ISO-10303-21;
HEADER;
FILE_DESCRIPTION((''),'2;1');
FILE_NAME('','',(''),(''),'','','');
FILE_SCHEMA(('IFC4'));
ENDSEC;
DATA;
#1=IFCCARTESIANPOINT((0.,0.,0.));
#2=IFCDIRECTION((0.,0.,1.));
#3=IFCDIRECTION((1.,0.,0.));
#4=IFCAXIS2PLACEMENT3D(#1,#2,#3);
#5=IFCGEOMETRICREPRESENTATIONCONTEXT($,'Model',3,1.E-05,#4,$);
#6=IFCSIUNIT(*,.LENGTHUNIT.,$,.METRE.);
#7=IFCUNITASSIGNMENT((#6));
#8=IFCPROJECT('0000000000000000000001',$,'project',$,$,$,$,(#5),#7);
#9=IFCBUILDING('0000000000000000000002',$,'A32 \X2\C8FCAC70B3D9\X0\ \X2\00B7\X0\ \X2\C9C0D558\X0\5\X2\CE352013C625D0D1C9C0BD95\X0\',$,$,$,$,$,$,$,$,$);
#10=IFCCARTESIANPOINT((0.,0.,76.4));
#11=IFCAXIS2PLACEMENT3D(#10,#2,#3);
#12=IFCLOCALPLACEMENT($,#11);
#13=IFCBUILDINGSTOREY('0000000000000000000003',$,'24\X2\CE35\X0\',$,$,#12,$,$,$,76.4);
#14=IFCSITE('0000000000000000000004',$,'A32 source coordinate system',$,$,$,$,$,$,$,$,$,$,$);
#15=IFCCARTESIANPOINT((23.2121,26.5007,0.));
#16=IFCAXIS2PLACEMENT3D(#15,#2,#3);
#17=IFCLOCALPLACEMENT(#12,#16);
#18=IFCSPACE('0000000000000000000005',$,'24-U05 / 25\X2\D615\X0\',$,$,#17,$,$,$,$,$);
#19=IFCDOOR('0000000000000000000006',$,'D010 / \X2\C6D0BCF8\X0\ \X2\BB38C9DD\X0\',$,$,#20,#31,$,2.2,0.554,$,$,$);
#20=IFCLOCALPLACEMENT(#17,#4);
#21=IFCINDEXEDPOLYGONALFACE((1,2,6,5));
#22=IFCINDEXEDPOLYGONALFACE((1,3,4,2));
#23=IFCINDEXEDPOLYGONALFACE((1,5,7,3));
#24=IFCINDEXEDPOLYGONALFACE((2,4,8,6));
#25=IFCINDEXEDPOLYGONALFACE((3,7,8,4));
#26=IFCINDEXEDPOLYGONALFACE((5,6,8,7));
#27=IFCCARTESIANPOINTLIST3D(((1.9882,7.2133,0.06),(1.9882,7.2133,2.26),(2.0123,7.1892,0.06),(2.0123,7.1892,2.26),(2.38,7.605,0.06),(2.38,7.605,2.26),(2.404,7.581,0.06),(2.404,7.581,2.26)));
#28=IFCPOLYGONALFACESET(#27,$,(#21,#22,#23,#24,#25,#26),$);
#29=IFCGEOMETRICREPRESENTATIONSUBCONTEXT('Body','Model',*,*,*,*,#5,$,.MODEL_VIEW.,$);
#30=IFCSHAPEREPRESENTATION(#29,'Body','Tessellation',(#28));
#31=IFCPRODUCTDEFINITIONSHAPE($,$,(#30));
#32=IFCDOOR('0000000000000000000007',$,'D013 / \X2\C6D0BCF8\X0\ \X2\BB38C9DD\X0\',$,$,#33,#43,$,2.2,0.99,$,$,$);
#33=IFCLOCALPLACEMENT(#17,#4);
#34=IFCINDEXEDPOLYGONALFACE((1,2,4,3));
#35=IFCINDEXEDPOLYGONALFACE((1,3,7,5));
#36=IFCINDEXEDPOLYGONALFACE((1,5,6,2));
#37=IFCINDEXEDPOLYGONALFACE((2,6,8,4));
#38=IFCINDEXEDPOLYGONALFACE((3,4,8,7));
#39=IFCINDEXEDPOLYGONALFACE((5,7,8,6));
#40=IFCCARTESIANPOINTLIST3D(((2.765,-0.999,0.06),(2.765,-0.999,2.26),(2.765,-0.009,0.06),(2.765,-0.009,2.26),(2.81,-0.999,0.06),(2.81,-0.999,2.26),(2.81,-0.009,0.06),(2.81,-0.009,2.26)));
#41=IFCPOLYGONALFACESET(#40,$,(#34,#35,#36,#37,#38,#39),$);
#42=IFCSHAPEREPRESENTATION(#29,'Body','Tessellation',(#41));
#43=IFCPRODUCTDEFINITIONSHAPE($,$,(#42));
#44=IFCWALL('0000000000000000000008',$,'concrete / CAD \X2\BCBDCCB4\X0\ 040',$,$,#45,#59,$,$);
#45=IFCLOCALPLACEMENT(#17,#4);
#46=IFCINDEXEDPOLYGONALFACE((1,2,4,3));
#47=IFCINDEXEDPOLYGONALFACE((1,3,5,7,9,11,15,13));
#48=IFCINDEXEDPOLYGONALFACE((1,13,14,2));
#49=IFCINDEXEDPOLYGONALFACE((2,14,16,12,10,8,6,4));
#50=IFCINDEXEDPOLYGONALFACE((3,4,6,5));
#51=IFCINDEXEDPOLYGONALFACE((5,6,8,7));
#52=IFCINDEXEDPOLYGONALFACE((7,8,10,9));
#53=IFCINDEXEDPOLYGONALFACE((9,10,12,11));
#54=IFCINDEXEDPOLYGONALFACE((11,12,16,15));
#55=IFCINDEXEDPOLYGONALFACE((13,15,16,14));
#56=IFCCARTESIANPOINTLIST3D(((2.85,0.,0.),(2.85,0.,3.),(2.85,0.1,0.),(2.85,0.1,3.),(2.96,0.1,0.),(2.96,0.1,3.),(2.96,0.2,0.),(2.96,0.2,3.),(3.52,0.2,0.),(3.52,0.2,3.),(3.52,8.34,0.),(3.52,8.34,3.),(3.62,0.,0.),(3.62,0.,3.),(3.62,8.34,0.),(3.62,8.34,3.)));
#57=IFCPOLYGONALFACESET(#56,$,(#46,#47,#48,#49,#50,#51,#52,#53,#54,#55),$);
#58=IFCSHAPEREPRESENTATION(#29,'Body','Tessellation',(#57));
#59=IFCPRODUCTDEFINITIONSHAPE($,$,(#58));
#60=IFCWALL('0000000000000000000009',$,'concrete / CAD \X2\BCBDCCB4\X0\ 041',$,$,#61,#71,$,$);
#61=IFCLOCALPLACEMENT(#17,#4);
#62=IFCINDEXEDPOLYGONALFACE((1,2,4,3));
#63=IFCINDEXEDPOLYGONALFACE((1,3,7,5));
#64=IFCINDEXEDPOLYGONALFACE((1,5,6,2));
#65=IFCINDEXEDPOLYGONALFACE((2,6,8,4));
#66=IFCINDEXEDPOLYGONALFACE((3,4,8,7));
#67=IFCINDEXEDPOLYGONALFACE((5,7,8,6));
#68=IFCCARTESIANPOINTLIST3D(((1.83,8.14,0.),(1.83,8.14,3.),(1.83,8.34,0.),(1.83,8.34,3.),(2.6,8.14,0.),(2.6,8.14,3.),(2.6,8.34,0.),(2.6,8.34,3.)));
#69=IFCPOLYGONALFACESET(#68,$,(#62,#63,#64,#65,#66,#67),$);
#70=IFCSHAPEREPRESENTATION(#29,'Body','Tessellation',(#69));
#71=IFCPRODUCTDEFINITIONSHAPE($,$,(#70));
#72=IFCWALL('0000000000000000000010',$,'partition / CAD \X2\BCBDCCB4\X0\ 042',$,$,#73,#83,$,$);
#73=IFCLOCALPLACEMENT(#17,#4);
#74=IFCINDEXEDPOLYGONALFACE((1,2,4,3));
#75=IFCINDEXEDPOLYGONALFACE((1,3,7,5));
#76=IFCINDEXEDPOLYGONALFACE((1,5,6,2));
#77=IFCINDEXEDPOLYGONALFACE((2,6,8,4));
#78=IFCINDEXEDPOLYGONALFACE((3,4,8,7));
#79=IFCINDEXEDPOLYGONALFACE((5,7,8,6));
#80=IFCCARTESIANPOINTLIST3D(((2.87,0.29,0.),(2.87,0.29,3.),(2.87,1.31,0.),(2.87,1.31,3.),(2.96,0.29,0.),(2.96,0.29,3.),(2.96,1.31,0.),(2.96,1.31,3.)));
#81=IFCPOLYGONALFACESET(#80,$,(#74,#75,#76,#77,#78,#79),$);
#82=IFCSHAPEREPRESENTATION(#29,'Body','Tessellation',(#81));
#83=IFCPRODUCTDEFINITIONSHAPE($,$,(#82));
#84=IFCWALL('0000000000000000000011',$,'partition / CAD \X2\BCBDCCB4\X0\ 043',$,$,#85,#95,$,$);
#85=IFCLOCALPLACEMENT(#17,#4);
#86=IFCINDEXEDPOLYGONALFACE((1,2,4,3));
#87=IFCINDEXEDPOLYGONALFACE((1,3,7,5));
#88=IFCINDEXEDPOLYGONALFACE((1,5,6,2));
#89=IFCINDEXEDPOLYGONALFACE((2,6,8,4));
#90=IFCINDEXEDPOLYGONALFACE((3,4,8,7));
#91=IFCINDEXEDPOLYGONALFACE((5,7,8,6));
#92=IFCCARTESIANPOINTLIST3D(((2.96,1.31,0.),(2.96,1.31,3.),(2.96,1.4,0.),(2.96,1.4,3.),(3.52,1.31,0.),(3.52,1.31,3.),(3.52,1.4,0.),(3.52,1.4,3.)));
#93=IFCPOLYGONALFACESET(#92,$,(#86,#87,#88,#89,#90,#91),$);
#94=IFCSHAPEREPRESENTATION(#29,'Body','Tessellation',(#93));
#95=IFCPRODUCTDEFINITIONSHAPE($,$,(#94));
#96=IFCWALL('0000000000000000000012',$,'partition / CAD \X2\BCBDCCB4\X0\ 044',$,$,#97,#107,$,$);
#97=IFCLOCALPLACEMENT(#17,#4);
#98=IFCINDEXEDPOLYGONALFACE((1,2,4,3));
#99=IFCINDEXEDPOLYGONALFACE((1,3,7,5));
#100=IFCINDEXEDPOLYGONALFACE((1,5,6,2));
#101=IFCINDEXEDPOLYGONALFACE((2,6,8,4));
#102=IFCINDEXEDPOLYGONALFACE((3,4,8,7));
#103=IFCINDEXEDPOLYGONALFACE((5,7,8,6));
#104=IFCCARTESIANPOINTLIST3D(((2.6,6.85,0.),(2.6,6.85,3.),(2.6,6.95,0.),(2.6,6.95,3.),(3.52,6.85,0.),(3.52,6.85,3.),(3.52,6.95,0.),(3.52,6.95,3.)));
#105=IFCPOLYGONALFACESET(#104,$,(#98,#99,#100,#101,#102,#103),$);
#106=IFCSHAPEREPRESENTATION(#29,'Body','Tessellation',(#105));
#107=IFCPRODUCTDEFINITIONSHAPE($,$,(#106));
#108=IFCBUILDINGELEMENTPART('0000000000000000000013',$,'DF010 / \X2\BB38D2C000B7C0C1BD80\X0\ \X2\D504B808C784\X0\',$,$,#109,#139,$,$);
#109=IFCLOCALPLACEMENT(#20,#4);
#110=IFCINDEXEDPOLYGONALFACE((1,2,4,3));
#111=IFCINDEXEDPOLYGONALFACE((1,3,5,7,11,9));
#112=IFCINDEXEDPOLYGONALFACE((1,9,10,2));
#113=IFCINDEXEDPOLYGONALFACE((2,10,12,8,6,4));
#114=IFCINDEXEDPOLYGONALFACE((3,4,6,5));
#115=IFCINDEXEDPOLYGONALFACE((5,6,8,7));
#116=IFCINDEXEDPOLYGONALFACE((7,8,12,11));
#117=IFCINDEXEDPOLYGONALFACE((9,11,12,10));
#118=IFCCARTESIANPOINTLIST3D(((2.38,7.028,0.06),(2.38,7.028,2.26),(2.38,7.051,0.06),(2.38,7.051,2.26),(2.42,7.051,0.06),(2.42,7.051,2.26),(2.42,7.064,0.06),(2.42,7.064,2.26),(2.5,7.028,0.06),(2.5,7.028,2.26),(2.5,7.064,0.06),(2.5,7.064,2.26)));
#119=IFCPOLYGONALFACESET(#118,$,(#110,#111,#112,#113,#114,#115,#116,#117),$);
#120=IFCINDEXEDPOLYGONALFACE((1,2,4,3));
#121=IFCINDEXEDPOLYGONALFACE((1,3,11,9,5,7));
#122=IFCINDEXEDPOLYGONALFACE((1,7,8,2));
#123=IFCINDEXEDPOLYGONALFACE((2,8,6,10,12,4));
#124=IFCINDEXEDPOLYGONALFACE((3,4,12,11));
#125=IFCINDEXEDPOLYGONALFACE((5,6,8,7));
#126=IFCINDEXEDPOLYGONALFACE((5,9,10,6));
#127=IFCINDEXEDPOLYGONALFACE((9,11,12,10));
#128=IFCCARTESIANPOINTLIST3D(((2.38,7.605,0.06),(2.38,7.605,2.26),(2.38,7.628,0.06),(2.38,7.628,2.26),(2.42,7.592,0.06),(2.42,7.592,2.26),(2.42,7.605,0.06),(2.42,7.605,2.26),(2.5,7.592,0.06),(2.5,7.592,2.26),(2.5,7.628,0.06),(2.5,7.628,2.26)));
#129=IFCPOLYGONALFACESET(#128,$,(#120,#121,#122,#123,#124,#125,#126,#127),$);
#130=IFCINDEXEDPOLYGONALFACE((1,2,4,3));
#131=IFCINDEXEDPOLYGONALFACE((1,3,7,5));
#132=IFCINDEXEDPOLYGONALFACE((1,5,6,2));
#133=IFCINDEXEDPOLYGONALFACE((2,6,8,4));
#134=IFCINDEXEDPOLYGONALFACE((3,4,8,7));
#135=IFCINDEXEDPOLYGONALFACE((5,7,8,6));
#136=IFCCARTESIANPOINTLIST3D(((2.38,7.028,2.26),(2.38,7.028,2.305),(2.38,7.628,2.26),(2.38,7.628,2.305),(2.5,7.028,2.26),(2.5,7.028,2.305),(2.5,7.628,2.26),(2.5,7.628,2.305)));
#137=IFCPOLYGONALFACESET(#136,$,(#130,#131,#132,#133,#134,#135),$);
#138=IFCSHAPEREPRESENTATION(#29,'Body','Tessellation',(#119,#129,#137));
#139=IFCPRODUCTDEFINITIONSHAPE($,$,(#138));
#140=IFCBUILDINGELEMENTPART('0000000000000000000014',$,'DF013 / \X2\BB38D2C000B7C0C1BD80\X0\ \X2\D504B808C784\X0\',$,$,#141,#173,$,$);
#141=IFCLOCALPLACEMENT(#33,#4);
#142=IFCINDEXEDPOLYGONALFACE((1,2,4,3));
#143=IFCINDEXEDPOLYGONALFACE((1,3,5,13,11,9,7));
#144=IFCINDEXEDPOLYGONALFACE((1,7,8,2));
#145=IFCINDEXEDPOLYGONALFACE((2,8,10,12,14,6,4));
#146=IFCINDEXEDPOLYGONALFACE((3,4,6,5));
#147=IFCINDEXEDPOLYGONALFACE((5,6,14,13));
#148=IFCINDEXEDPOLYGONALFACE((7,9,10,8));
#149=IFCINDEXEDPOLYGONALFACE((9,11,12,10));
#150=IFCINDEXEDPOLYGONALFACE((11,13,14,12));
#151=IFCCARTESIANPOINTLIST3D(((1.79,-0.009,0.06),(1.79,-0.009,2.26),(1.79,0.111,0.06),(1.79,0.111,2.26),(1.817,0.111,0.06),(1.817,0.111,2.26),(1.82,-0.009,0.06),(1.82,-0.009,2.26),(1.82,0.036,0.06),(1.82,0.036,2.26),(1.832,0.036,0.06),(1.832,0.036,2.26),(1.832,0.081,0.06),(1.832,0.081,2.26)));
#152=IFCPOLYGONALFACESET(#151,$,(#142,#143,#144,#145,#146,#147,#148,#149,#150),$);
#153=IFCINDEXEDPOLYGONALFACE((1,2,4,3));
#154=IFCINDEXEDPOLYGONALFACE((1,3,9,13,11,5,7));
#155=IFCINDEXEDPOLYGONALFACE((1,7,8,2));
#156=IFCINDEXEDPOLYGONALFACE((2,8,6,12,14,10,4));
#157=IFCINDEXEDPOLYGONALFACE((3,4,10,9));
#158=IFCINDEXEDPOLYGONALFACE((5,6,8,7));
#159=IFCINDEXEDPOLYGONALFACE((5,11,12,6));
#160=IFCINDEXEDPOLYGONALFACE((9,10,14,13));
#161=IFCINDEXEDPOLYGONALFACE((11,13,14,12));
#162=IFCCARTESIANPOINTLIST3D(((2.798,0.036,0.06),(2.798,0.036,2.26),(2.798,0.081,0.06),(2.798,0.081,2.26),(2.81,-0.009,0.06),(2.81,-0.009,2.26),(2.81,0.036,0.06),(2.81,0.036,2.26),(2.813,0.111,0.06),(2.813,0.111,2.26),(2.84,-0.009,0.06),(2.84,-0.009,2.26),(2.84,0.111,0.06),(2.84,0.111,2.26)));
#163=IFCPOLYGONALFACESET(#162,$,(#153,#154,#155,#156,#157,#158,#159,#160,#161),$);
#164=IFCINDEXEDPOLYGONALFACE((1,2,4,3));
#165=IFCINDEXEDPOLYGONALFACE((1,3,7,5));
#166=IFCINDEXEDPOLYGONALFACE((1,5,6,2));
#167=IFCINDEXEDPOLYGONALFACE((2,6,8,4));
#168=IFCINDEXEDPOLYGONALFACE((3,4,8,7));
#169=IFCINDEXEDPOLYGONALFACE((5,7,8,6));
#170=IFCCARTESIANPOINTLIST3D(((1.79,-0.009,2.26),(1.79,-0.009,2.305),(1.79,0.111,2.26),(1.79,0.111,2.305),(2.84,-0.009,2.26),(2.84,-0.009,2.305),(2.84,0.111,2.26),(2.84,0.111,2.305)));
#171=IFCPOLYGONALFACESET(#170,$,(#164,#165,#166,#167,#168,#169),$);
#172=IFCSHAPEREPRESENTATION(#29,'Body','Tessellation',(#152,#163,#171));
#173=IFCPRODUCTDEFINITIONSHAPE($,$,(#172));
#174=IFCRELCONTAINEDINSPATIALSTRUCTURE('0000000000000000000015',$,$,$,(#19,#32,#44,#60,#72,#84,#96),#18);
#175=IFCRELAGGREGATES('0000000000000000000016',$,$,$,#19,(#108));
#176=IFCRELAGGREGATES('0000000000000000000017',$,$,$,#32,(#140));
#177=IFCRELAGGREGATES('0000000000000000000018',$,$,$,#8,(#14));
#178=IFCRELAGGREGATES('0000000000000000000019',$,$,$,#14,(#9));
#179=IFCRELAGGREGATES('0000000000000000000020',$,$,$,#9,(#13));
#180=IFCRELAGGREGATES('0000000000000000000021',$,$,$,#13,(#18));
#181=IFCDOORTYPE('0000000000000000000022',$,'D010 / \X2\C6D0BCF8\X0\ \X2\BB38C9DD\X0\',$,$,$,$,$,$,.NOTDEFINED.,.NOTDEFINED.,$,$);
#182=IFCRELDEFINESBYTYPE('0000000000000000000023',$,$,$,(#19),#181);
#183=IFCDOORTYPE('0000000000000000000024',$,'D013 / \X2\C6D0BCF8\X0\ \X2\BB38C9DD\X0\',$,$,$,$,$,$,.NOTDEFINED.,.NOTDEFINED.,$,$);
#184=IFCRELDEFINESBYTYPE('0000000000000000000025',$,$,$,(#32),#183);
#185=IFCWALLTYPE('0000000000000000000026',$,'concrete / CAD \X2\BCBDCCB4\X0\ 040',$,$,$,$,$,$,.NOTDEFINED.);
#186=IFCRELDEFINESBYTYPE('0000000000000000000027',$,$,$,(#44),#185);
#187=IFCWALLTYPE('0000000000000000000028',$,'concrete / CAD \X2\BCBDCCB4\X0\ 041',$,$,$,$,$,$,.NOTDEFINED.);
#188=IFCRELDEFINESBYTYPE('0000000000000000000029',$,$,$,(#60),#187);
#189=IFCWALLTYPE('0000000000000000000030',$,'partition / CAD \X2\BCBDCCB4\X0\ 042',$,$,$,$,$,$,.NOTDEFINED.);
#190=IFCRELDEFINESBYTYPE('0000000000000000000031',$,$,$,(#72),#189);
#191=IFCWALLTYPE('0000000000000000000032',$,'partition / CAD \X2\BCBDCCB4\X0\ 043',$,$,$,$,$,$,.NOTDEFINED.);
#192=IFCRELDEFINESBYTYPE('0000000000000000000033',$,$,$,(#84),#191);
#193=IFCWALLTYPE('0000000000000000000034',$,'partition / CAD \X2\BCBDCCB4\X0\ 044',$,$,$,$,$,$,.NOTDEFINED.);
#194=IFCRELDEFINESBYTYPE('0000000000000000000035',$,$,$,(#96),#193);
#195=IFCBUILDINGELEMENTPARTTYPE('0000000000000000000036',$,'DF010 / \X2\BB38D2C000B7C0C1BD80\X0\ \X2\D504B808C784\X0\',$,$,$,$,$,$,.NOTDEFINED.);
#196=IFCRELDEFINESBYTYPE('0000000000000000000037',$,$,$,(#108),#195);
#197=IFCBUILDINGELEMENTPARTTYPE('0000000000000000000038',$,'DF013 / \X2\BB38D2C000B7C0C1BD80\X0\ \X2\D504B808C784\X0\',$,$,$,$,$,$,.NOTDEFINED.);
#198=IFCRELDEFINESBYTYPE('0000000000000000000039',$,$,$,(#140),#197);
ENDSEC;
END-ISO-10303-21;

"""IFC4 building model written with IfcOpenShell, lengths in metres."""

from ifc_helpers import new_model, si_unit, frame, origin, origin_with_axes, place, context, subcontext, project, spatial, polyline, outline, extrude, source, transform, mapped, type_object, type_shapes, element, aggregate, save


model = new_model("IFC4")

# Units and contexts
model_context = context("Model", 3, precision=1e-05, world=origin_with_axes())
body_context = subcontext(model_context, "Body", "Model", "MODEL_VIEW")
ifc_project = project(units=[si_unit("LENGTHUNIT", "METRE")], contexts=[model_context])

# Site, building, storey, space
storey_placement = place(None, frame((0.0, 0.0, 76.4), z_axis=(0.0, 0.0, 1.0), x_axis=(1.0, 0.0, 0.0)))
space_placement = place(storey_placement, frame((23.2121, 26.5007, 0.0), z_axis=(0.0, 0.0, 1.0), x_axis=(1.0, 0.0, 0.0)))
site = spatial("IfcSite", under=ifc_project, Name="A32 source coordinate system")
building = spatial("IfcBuilding", under=site, Name="A32 주거동 · 지하5층–옥탑지붕")
storey = spatial("IfcBuildingStorey", under=building, at=storey_placement, Name="24층", Elevation=76.4)
space = spatial("IfcSpace", under=storey, at=space_placement, Name="24-U05 / 25형")

# Doors
door_type_1 = type_object("IfcDoorType", Name="D010 / 원본 문짝", OperationType="NOTDEFINED", PredefinedType="NOTDEFINED")
shared_shape_1 = source(origin(), body_context, "Body", "SweptSolid", [
    extrude(outline(polyline([(2.0123, 7.1892), (1.9882, 7.2133), (2.38, 7.605), (2.404, 7.581), (2.0123, 7.1892)])), frame((0.0, 0.0, 0.06)), (0.0, 0.0, 1.0), 2.2),
])
type_shapes(door_type_1, [shared_shape_1])
door_1_placement = place(space_placement, origin_with_axes())
door_1 = element("IfcDoor", 1, at=door_1_placement, inside=space, type_object=door_type_1, Name="D010 / 원본 문짝", OverallHeight=2.2, OverallWidth=0.554, context=body_context, shape_type="MappedRepresentation", body=[
    mapped(shared_shape_1, transform((0.0, 0.0, 0.0), scale=1.0)),
])
door_type_2 = type_object("IfcDoorType", Name="D013 / 원본 문짝", OperationType="NOTDEFINED", PredefinedType="NOTDEFINED")
shared_shape_2 = source(origin(), body_context, "Body", "SweptSolid", [
    extrude(outline(polyline([(2.81, -0.009), (2.81, -0.999), (2.765, -0.999), (2.765, -0.009), (2.81, -0.009)])), frame((0.0, 0.0, 0.06)), (0.0, 0.0, 1.0), 2.2),
])
type_shapes(door_type_2, [shared_shape_2])
door_2_placement = place(space_placement, origin_with_axes())
door_2 = element("IfcDoor", 2, at=door_2_placement, inside=space, type_object=door_type_2, Name="D013 / 원본 문짝", OverallHeight=2.2, OverallWidth=0.99, context=body_context, shape_type="MappedRepresentation", body=[
    mapped(shared_shape_2, transform((0.0, 0.0, 0.0), scale=1.0)),
])

# Walls
wall_type_1 = type_object("IfcWallType", Name="concrete / CAD 벽체 040", PredefinedType="NOTDEFINED")
shared_shape_3 = source(origin(), body_context, "Body", "SweptSolid", [
    extrude(outline(polyline([(3.62, 8.34), (3.62, 0.0), (2.85, 0.0), (2.85, 0.1), (2.96, 0.1), (2.96, 0.2), (3.52, 0.2), (3.52, 8.34), (3.62, 8.34)])), origin(), (0.0, 0.0, 1.0), 3.0),
])
type_shapes(wall_type_1, [shared_shape_3])
wall_1_placement = place(space_placement, origin_with_axes())
element("IfcWall", 3, at=wall_1_placement, inside=space, type_object=wall_type_1, Name="concrete / CAD 벽체 040", context=body_context, shape_type="MappedRepresentation", body=[
    mapped(shared_shape_3, transform((0.0, 0.0, 0.0), scale=1.0)),
])
wall_type_2 = type_object("IfcWallType", Name="concrete / CAD 벽체 041", PredefinedType="NOTDEFINED")
shared_shape_4 = source(origin(), body_context, "Body", "SweptSolid", [
    extrude(outline(polyline([(2.6, 8.14), (1.83, 8.14), (1.83, 8.34), (2.6, 8.34), (2.6, 8.14)])), origin(), (0.0, 0.0, 1.0), 3.0),
])
type_shapes(wall_type_2, [shared_shape_4])
wall_2_placement = place(space_placement, origin_with_axes())
element("IfcWall", 4, at=wall_2_placement, inside=space, type_object=wall_type_2, Name="concrete / CAD 벽체 041", context=body_context, shape_type="MappedRepresentation", body=[
    mapped(shared_shape_4, transform((0.0, 0.0, 0.0), scale=1.0)),
])
wall_type_3 = type_object("IfcWallType", Name="partition / CAD 벽체 042", PredefinedType="NOTDEFINED")
shared_shape_5 = source(origin(), body_context, "Body", "SweptSolid", [
    extrude(outline(polyline([(2.87, 1.31), (2.96, 1.31), (2.96, 0.29), (2.87, 0.29), (2.87, 1.31)])), origin(), (0.0, 0.0, 1.0), 3.0),
])
type_shapes(wall_type_3, [shared_shape_5])
wall_3_placement = place(space_placement, origin_with_axes())
element("IfcWall", 5, at=wall_3_placement, inside=space, type_object=wall_type_3, Name="partition / CAD 벽체 042", context=body_context, shape_type="MappedRepresentation", body=[
    mapped(shared_shape_5, transform((0.0, 0.0, 0.0), scale=1.0)),
])
wall_type_4 = type_object("IfcWallType", Name="partition / CAD 벽체 043", PredefinedType="NOTDEFINED")
shared_shape_6 = source(origin(), body_context, "Body", "SweptSolid", [
    extrude(outline(polyline([(3.52, 1.4), (3.52, 1.31), (2.96, 1.31), (2.96, 1.4), (3.52, 1.4)])), origin(), (0.0, 0.0, 1.0), 3.0),
])
type_shapes(wall_type_4, [shared_shape_6])
wall_4_placement = place(space_placement, origin_with_axes())
element("IfcWall", 6, at=wall_4_placement, inside=space, type_object=wall_type_4, Name="partition / CAD 벽체 043", context=body_context, shape_type="MappedRepresentation", body=[
    mapped(shared_shape_6, transform((0.0, 0.0, 0.0), scale=1.0)),
])
wall_type_5 = type_object("IfcWallType", Name="partition / CAD 벽체 044", PredefinedType="NOTDEFINED")
shared_shape_7 = source(origin(), body_context, "Body", "SweptSolid", [
    extrude(outline(polyline([(3.52, 6.95), (3.52, 6.85), (2.6, 6.85), (2.6, 6.95), (3.52, 6.95)])), origin(), (0.0, 0.0, 1.0), 3.0),
])
type_shapes(wall_type_5, [shared_shape_7])
wall_5_placement = place(space_placement, origin_with_axes())
element("IfcWall", 7, at=wall_5_placement, inside=space, type_object=wall_type_5, Name="partition / CAD 벽체 044", context=body_context, shape_type="MappedRepresentation", body=[
    mapped(shared_shape_7, transform((0.0, 0.0, 0.0), scale=1.0)),
])

# Building element parts
building_element_part_type_1 = type_object("IfcBuildingElementPartType", Name="DF010 / 문틀·상부 프레임", PredefinedType="NOTDEFINED")
shared_shape_8 = source(origin(), body_context, "Body", "SweptSolid", [
    extrude(outline(polyline([(2.38, 7.028), (2.38, 7.051), (2.42, 7.051), (2.42, 7.064), (2.5, 7.064), (2.5, 7.028), (2.38, 7.028)])), frame((0.0, 0.0, 0.06)), (0.0, 0.0, 1.0), 2.2),
    extrude(outline(polyline([(2.5, 7.592), (2.42, 7.592), (2.42, 7.605), (2.38, 7.605), (2.38, 7.628), (2.5, 7.628), (2.5, 7.592)])), frame((0.0, 0.0, 0.06)), (0.0, 0.0, 1.0), 2.2),
    extrude(outline(polyline([(2.38, 7.028), (2.38, 7.628), (2.5, 7.628), (2.5, 7.028), (2.38, 7.028)])), frame((0.0, 0.0, 2.26)), (0.0, 0.0, 1.0), 0.045),
])
type_shapes(building_element_part_type_1, [shared_shape_8])
building_element_part_1_placement = place(door_1_placement, origin_with_axes())
building_element_part_1 = element("IfcBuildingElementPart", 8, at=building_element_part_1_placement, type_object=building_element_part_type_1, Name="DF010 / 문틀·상부 프레임", context=body_context, shape_type="MappedRepresentation", body=[
    mapped(shared_shape_8, transform((0.0, 0.0, 0.0), scale=1.0)),
])
aggregate(door_1, [building_element_part_1])
building_element_part_type_2 = type_object("IfcBuildingElementPartType", Name="DF013 / 문틀·상부 프레임", PredefinedType="NOTDEFINED")
shared_shape_9 = source(origin(), body_context, "Body", "SweptSolid", [
    extrude(outline(polyline([(1.79, 0.111), (1.817, 0.111), (1.832, 0.081), (1.832, 0.036), (1.82, 0.036), (1.82, -0.009), (1.79, -0.009), (1.79, 0.111)])), frame((0.0, 0.0, 0.06)), (0.0, 0.0, 1.0), 2.2),
    extrude(outline(polyline([(2.81, -0.009), (2.81, 0.036), (2.798, 0.036), (2.798, 0.081), (2.813, 0.111), (2.84, 0.111), (2.84, -0.009), (2.81, -0.009)])), frame((0.0, 0.0, 0.06)), (0.0, 0.0, 1.0), 2.2),
    extrude(outline(polyline([(1.79, -0.009), (1.79, 0.111), (2.84, 0.111), (2.84, -0.009), (1.79, -0.009)])), frame((0.0, 0.0, 2.26)), (0.0, 0.0, 1.0), 0.045),
])
type_shapes(building_element_part_type_2, [shared_shape_9])
building_element_part_2_placement = place(door_2_placement, origin_with_axes())
building_element_part_2 = element("IfcBuildingElementPart", 9, at=building_element_part_2_placement, type_object=building_element_part_type_2, Name="DF013 / 문틀·상부 프레임", context=body_context, shape_type="MappedRepresentation", body=[
    mapped(shared_shape_9, transform((0.0, 0.0, 0.0), scale=1.0)),
])
aggregate(door_2, [building_element_part_2])

save(model, "model.ifc")
